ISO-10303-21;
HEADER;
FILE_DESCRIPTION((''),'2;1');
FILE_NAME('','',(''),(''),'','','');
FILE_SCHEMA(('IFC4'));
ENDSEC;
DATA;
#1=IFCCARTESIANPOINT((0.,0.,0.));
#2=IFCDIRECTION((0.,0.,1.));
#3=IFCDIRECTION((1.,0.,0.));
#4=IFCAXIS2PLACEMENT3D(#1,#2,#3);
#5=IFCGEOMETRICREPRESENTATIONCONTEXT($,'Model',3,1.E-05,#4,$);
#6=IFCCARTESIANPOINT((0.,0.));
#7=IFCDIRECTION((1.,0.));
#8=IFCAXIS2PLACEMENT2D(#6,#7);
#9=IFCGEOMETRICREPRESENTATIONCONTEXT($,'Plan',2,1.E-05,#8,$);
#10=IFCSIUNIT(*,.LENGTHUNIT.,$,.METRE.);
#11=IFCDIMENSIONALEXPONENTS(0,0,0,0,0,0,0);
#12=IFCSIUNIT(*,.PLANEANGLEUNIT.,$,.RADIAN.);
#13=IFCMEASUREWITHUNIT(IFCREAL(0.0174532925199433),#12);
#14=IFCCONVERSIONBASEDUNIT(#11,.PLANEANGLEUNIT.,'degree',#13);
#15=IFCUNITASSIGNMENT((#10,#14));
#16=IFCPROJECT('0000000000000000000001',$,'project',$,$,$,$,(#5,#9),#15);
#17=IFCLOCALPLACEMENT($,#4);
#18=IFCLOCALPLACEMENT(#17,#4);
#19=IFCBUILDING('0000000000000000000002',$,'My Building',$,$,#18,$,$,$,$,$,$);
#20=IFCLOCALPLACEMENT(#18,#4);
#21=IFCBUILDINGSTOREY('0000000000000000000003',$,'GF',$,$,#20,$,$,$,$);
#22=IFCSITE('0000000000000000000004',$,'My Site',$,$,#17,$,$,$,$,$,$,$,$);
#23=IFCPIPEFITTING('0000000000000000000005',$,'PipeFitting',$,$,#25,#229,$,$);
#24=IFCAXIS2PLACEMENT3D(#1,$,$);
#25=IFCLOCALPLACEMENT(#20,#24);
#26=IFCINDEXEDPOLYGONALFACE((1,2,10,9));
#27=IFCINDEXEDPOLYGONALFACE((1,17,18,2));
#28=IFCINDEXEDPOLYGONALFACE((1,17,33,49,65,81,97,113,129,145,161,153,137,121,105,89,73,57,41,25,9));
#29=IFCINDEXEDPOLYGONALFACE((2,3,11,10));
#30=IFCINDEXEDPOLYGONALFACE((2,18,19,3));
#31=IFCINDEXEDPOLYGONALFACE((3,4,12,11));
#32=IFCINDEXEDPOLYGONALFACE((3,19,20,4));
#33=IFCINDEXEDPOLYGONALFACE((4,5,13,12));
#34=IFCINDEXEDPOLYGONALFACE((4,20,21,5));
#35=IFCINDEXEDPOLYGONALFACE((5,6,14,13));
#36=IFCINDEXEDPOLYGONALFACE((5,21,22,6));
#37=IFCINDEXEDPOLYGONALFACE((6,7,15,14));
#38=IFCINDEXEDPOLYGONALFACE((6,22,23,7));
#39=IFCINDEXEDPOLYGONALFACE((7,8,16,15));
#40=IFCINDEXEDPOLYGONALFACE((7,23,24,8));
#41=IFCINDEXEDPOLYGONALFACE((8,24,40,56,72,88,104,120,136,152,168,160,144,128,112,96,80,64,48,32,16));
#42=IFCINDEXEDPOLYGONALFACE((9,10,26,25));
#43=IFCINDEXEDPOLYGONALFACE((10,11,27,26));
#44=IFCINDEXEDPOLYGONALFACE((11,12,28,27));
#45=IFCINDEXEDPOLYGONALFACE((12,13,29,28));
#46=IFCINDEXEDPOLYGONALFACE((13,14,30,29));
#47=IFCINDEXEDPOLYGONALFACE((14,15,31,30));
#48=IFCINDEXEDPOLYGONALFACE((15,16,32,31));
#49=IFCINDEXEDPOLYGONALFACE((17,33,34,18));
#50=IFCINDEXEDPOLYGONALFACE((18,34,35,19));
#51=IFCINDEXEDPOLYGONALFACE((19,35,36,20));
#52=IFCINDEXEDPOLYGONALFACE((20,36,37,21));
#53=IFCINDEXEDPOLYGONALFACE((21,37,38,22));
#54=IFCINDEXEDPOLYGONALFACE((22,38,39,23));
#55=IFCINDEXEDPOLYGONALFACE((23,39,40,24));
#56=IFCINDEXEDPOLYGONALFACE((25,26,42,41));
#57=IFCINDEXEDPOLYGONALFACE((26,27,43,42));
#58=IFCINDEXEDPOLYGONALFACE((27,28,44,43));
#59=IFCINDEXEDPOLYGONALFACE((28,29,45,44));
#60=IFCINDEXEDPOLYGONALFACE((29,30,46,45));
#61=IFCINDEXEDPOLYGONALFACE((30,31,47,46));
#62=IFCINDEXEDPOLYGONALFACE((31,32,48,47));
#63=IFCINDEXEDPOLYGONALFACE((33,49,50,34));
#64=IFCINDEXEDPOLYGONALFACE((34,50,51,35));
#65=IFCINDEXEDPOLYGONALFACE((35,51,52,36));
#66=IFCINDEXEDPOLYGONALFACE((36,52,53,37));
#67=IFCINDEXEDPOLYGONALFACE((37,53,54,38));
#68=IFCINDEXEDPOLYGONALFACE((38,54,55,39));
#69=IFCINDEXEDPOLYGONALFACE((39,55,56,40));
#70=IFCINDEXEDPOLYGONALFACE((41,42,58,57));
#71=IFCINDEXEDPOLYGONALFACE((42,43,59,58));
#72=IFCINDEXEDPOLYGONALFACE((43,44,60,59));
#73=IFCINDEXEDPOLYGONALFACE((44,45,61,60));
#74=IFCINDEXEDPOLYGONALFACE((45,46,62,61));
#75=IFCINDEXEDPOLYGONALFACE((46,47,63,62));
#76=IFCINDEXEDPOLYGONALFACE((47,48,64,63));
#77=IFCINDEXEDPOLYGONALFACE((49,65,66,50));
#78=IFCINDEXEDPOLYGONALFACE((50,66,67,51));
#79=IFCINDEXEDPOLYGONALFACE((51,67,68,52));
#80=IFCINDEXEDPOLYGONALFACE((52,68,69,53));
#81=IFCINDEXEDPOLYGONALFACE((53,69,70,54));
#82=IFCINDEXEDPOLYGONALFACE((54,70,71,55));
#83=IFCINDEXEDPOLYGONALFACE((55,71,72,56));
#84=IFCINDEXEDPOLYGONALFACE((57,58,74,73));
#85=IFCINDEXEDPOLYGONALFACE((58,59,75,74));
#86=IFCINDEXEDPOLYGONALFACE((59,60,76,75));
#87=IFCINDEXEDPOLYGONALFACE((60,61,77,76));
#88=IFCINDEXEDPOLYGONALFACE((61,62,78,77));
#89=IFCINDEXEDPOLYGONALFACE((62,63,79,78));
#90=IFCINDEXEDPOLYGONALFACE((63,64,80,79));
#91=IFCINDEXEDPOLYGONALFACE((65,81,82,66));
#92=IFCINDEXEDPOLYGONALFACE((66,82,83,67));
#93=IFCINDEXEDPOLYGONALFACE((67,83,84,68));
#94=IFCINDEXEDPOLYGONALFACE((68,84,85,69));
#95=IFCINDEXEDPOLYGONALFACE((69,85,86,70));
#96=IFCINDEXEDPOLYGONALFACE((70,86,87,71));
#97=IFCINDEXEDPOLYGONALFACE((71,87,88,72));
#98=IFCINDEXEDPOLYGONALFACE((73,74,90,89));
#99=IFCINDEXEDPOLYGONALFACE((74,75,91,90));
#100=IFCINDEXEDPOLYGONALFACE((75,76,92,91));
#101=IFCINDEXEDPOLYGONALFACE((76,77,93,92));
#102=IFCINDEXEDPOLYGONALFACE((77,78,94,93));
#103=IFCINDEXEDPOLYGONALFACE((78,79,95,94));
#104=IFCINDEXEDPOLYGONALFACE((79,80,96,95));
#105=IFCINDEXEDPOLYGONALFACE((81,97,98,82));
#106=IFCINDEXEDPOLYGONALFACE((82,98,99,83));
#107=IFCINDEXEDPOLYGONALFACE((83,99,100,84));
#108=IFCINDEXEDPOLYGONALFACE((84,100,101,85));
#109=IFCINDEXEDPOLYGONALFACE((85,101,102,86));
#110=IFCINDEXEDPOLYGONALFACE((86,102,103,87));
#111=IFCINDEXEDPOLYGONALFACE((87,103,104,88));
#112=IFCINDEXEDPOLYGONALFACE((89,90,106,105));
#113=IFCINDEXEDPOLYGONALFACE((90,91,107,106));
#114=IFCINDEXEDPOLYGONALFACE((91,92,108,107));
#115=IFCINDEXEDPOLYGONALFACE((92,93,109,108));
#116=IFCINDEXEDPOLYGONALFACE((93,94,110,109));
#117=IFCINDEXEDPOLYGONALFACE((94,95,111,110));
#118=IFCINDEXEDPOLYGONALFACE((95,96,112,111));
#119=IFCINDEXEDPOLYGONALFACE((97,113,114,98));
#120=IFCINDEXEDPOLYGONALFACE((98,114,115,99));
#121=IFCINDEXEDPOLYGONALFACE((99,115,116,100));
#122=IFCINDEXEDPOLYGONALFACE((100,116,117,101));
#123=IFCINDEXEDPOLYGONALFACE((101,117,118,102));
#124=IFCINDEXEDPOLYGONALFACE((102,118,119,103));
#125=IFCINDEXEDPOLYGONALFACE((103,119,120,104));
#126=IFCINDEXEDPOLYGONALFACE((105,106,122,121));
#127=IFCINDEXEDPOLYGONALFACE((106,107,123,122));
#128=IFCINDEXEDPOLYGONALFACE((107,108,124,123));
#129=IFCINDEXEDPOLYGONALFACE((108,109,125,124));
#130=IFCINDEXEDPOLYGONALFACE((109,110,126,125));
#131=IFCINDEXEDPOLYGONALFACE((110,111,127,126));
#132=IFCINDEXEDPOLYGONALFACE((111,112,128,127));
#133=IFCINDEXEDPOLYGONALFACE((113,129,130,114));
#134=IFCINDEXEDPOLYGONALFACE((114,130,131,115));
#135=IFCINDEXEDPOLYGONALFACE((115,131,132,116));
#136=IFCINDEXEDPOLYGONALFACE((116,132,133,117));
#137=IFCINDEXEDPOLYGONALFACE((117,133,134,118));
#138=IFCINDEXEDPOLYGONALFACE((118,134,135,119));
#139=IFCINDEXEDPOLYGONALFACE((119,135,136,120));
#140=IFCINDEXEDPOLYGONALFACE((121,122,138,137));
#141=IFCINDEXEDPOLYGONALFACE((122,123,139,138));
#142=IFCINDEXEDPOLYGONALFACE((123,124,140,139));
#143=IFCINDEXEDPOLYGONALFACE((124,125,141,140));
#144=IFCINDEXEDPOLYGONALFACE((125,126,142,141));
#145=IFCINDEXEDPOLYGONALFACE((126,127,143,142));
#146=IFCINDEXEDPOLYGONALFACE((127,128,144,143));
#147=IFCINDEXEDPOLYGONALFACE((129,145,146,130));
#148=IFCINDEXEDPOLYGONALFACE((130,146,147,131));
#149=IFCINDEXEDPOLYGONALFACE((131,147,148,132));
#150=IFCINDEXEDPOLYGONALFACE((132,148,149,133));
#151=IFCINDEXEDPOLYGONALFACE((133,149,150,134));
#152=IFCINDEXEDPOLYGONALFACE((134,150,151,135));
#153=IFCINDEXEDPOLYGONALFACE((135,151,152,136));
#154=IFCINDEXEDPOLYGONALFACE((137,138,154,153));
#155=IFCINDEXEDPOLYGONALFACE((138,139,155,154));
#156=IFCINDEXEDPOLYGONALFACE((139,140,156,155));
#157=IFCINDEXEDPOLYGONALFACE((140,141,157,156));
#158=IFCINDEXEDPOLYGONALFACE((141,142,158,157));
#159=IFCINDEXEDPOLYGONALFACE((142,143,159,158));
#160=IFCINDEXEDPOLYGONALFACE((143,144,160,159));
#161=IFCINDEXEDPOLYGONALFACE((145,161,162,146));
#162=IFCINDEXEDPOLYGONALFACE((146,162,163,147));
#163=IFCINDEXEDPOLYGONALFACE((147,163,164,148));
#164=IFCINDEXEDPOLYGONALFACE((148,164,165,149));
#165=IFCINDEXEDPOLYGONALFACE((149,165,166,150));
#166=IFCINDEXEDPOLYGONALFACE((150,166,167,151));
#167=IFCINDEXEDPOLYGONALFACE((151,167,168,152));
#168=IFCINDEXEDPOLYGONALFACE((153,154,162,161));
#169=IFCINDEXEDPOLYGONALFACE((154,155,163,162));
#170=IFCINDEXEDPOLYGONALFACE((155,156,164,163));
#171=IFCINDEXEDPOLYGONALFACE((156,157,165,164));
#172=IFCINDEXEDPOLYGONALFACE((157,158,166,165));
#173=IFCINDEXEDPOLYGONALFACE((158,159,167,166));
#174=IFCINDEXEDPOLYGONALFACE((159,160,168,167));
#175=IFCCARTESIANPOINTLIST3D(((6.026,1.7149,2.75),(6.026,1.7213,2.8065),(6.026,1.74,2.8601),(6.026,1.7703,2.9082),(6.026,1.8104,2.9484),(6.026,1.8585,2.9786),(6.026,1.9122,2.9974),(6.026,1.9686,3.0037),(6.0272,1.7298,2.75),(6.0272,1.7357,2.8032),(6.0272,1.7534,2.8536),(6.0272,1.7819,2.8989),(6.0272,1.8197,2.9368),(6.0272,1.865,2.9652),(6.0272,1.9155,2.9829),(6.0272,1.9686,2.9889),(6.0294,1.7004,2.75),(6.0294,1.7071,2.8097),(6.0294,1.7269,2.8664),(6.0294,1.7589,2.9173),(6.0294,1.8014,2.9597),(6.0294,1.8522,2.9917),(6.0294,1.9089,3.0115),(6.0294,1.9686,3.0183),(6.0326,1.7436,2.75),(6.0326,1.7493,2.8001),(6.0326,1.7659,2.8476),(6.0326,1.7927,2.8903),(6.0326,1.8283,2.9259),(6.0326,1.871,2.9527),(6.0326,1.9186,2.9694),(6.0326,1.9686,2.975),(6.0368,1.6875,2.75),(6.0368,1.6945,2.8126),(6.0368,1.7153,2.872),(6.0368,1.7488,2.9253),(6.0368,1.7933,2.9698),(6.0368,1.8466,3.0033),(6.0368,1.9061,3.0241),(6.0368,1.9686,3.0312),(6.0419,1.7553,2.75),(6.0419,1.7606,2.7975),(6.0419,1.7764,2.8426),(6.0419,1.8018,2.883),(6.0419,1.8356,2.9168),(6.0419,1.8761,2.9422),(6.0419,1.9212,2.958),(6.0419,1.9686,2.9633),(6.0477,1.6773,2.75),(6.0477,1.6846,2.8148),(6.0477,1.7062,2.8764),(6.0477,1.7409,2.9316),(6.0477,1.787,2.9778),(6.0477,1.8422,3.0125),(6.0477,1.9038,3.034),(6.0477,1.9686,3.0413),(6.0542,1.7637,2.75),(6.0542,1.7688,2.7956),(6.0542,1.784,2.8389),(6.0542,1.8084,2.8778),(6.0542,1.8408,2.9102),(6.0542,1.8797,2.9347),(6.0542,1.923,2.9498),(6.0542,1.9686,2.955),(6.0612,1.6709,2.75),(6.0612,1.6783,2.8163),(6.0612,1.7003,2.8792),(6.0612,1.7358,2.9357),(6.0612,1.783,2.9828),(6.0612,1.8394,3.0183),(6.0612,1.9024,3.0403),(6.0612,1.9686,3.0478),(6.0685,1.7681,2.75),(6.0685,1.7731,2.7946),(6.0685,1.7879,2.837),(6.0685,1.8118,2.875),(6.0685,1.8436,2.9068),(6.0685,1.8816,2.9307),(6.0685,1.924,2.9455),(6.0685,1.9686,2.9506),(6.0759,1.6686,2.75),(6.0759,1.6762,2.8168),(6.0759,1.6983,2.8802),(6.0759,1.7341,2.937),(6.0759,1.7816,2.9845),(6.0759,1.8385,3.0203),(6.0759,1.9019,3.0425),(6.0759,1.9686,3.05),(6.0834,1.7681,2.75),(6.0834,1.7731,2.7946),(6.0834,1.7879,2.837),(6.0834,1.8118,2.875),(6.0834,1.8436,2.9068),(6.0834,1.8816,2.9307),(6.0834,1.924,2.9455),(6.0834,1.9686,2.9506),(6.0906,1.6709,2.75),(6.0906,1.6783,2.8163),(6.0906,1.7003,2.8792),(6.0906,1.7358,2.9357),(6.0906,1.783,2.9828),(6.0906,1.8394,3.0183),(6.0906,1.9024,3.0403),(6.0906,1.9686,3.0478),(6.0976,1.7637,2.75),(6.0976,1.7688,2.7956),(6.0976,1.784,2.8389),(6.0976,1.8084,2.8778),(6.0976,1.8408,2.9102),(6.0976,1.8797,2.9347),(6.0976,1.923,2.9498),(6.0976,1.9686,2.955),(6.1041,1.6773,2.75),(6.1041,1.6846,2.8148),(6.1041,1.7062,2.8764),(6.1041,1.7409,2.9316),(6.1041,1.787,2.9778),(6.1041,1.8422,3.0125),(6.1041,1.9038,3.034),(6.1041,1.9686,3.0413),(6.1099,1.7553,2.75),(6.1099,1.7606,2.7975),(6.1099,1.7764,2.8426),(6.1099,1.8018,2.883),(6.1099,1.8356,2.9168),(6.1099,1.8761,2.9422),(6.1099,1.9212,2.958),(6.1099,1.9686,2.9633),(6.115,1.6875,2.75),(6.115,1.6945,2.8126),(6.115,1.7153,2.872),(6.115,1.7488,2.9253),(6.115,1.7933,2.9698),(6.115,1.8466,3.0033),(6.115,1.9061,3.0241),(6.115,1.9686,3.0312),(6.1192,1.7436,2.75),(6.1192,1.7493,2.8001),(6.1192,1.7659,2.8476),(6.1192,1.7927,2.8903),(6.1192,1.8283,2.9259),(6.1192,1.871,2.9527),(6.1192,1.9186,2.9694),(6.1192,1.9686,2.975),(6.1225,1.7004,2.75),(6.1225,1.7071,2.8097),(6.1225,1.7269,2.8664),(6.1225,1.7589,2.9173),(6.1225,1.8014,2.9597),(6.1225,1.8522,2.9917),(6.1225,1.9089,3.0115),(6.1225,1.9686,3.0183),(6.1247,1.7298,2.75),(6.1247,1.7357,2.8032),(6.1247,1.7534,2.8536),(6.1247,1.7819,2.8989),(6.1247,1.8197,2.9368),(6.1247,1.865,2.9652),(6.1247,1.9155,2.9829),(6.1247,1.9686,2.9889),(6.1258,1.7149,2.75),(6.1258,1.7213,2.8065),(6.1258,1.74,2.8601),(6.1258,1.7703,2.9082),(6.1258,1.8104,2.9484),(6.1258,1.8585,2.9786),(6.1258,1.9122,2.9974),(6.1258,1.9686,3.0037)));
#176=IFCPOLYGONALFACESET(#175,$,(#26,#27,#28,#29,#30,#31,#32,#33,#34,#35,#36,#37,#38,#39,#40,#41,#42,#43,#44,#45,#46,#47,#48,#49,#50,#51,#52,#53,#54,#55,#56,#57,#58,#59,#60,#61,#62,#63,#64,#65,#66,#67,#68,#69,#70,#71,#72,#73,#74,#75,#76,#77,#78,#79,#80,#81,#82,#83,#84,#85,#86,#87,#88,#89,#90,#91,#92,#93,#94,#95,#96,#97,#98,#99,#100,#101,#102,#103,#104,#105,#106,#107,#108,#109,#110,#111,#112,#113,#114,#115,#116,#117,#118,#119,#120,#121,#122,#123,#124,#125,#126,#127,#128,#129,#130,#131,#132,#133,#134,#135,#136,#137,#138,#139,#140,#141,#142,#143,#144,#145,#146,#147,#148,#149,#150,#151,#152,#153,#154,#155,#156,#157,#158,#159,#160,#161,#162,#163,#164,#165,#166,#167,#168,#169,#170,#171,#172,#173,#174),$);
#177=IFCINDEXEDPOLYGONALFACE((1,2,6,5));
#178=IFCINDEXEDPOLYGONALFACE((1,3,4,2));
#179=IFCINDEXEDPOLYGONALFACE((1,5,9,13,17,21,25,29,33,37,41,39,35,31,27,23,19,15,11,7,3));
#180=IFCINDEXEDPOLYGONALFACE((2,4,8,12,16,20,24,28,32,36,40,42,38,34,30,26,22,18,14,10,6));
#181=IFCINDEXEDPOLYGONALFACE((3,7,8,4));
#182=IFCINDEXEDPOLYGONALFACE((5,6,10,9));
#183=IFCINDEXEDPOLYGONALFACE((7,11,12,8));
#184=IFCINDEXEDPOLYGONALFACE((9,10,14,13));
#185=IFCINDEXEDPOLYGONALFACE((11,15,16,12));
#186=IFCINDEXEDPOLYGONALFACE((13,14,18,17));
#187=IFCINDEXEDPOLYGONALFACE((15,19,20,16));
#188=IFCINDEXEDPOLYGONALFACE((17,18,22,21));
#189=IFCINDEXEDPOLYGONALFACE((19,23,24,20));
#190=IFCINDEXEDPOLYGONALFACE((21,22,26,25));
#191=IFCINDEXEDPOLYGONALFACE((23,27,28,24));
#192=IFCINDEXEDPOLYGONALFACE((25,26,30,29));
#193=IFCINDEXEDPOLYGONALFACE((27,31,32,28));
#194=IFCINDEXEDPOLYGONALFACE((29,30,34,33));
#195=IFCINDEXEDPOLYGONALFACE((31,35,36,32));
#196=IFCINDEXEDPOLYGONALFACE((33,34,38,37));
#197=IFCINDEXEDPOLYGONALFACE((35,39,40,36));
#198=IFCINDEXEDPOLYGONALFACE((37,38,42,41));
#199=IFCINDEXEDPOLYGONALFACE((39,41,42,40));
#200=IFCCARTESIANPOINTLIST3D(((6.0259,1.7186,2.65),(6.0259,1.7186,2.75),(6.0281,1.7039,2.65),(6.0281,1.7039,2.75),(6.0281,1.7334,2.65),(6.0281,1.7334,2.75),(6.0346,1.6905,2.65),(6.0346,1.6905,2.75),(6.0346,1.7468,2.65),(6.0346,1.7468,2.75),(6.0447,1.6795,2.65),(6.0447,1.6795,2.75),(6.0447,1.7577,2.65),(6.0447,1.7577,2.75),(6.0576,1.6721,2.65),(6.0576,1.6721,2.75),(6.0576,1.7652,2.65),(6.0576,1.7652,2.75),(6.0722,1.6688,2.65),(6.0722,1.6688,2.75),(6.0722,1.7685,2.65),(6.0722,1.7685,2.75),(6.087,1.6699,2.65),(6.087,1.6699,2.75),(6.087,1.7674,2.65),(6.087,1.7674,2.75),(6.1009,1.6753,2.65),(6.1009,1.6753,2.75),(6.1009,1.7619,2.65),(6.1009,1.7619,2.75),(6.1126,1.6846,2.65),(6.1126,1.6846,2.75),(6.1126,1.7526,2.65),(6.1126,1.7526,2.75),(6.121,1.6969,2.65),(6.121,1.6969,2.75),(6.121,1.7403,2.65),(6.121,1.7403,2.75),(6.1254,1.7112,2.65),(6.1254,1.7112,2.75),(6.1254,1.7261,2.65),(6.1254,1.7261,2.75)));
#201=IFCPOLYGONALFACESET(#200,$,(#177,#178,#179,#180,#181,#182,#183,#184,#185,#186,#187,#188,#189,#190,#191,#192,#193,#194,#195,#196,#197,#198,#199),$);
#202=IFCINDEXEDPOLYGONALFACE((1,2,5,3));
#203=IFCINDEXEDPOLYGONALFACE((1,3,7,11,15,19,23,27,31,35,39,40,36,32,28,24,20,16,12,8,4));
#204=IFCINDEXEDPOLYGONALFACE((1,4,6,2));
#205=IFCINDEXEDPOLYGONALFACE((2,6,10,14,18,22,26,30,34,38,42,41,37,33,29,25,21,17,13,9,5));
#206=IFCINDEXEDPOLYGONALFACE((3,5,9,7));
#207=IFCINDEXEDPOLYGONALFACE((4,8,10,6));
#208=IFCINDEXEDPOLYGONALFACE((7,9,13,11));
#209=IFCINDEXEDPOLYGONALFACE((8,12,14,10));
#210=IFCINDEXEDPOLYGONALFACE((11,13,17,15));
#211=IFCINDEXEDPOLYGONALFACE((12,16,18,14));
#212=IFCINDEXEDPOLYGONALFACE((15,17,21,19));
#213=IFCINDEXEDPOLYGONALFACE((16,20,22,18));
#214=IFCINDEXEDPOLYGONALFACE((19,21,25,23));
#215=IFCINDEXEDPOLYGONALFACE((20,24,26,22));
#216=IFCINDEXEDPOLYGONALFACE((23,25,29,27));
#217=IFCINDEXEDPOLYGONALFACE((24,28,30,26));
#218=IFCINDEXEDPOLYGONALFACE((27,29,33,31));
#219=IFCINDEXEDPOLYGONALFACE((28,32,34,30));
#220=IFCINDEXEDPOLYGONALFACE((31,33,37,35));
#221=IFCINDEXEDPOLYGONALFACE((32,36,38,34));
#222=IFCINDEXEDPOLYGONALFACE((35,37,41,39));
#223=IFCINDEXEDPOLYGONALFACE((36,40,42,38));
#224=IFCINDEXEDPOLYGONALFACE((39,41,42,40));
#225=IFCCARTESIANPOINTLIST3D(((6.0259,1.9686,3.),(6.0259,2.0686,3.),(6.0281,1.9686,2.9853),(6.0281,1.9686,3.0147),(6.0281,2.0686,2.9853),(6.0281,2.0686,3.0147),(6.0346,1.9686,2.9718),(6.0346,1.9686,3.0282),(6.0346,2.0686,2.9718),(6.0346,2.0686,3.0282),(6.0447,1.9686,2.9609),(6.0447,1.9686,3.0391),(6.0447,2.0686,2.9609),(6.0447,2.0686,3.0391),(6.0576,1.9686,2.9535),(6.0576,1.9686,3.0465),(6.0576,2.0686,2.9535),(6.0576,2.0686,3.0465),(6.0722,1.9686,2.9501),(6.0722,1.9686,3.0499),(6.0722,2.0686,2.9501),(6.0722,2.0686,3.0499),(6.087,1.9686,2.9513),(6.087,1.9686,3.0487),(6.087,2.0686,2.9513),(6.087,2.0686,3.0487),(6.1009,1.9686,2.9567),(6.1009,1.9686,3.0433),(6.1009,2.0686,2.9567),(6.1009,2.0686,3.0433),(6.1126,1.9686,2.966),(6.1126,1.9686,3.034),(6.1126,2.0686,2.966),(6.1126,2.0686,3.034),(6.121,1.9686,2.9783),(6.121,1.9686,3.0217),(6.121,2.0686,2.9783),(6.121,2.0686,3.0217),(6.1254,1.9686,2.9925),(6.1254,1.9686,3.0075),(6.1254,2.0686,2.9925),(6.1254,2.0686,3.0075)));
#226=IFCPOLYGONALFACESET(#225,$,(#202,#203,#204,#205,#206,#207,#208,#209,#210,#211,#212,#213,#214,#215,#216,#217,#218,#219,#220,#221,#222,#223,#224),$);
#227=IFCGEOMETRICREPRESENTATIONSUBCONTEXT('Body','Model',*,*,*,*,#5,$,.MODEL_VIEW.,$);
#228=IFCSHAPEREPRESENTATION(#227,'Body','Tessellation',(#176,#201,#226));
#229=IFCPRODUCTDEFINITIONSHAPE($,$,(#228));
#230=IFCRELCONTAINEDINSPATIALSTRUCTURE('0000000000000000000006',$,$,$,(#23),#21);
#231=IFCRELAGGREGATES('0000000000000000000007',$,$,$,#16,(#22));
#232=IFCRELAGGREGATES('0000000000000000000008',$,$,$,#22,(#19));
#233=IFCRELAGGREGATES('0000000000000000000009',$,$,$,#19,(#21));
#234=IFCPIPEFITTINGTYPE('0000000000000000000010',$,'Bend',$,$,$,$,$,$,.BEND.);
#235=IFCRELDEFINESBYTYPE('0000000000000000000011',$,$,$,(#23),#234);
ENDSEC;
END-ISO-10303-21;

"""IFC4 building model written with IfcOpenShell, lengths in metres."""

from ifc_helpers import new_model, entity, si_unit, converted_unit, frame, origin_with_axes, origin_2d_with_axis, place, context, subcontext, project, spatial, circle, extrude, source, transform, mapped, type_object, type_shapes, element, save


model = new_model("IFC4")

# Units and contexts
model_context = context("Model", 3, precision=1e-05, world=origin_with_axes())
plan_context = context("Plan", 2, precision=1e-05, world=origin_2d_with_axis())
body_context = subcontext(model_context, "Body", "Model", "MODEL_VIEW")
ifc_project = project(units=[si_unit("LENGTHUNIT", "METRE"), converted_unit("PLANEANGLEUNIT", "degree", entity("IfcReal", 0.0174532925199433), si_unit("PLANEANGLEUNIT", "RADIAN"), dimensions=[0, 0, 0, 0, 0, 0, 0])], contexts=[model_context, plan_context])

# Site, building, storey
site_placement = place(None, origin_with_axes())
site = spatial("IfcSite", under=ifc_project, at=site_placement, Name="My Site")
building_placement = place(site_placement, origin_with_axes())
building = spatial("IfcBuilding", under=site, at=building_placement, Name="My Building")
storey_placement = place(building_placement, origin_with_axes())
storey = spatial("IfcBuildingStorey", under=building, at=storey_placement, Name="GF")

# Pipe fitting
pipe_fitting_type = type_object("IfcPipeFittingType", Name="Bend", PredefinedType="BEND")
shared_shape = source(origin_with_axes(), body_context, "Body", "SolidModel", [
    entity("IfcSweptDiskSolid", entity("IfcIndexedPolyCurve", entity("IfcCartesianPointList3D", [[0.0, 0.0, -0.1], [0.0, 0.0732, -0.2768], [0.0, 0.25, -0.35]]), [entity("IfcArcIndex", [1, 2, 3])]), 0.05),
    extrude(circle(Radius=0.05), origin_with_axes(), (0.0, 0.0, -1.0), 0.1),
    extrude(circle(Radius=0.05), frame((0.0, 0.25, -0.35), z_axis=(0.0, 1.0, 0.0), x_axis=(1.0, 0.0, 0.0)), (0.0, 0.0, 1.0), 0.1),
])
type_shapes(pipe_fitting_type, [shared_shape])
for number, where, z_axis, x_axis, name in (
    (1, (6.0759, 1.7186, 2.65), (0.0, 0.0, -1.0), (-1.0, 0.0, 0.0), "PipeFitting"),
):
    element("IfcPipeFitting", number, at=place(storey_placement, frame(where, z_axis=z_axis, x_axis=x_axis)), inside=storey, type_object=pipe_fitting_type, Name=name, context=body_context, shape_type="MappedRepresentation", body=[
        mapped(shared_shape, transform((0.0, 0.0, 0.0), x_axis=(1.0, 0.0, 0.0), y_axis=(0.0, 1.0, 0.0), z_axis=(0.0, 0.0, 1.0), scale=1.0)),
    ])

save(model, "model.ifc")
